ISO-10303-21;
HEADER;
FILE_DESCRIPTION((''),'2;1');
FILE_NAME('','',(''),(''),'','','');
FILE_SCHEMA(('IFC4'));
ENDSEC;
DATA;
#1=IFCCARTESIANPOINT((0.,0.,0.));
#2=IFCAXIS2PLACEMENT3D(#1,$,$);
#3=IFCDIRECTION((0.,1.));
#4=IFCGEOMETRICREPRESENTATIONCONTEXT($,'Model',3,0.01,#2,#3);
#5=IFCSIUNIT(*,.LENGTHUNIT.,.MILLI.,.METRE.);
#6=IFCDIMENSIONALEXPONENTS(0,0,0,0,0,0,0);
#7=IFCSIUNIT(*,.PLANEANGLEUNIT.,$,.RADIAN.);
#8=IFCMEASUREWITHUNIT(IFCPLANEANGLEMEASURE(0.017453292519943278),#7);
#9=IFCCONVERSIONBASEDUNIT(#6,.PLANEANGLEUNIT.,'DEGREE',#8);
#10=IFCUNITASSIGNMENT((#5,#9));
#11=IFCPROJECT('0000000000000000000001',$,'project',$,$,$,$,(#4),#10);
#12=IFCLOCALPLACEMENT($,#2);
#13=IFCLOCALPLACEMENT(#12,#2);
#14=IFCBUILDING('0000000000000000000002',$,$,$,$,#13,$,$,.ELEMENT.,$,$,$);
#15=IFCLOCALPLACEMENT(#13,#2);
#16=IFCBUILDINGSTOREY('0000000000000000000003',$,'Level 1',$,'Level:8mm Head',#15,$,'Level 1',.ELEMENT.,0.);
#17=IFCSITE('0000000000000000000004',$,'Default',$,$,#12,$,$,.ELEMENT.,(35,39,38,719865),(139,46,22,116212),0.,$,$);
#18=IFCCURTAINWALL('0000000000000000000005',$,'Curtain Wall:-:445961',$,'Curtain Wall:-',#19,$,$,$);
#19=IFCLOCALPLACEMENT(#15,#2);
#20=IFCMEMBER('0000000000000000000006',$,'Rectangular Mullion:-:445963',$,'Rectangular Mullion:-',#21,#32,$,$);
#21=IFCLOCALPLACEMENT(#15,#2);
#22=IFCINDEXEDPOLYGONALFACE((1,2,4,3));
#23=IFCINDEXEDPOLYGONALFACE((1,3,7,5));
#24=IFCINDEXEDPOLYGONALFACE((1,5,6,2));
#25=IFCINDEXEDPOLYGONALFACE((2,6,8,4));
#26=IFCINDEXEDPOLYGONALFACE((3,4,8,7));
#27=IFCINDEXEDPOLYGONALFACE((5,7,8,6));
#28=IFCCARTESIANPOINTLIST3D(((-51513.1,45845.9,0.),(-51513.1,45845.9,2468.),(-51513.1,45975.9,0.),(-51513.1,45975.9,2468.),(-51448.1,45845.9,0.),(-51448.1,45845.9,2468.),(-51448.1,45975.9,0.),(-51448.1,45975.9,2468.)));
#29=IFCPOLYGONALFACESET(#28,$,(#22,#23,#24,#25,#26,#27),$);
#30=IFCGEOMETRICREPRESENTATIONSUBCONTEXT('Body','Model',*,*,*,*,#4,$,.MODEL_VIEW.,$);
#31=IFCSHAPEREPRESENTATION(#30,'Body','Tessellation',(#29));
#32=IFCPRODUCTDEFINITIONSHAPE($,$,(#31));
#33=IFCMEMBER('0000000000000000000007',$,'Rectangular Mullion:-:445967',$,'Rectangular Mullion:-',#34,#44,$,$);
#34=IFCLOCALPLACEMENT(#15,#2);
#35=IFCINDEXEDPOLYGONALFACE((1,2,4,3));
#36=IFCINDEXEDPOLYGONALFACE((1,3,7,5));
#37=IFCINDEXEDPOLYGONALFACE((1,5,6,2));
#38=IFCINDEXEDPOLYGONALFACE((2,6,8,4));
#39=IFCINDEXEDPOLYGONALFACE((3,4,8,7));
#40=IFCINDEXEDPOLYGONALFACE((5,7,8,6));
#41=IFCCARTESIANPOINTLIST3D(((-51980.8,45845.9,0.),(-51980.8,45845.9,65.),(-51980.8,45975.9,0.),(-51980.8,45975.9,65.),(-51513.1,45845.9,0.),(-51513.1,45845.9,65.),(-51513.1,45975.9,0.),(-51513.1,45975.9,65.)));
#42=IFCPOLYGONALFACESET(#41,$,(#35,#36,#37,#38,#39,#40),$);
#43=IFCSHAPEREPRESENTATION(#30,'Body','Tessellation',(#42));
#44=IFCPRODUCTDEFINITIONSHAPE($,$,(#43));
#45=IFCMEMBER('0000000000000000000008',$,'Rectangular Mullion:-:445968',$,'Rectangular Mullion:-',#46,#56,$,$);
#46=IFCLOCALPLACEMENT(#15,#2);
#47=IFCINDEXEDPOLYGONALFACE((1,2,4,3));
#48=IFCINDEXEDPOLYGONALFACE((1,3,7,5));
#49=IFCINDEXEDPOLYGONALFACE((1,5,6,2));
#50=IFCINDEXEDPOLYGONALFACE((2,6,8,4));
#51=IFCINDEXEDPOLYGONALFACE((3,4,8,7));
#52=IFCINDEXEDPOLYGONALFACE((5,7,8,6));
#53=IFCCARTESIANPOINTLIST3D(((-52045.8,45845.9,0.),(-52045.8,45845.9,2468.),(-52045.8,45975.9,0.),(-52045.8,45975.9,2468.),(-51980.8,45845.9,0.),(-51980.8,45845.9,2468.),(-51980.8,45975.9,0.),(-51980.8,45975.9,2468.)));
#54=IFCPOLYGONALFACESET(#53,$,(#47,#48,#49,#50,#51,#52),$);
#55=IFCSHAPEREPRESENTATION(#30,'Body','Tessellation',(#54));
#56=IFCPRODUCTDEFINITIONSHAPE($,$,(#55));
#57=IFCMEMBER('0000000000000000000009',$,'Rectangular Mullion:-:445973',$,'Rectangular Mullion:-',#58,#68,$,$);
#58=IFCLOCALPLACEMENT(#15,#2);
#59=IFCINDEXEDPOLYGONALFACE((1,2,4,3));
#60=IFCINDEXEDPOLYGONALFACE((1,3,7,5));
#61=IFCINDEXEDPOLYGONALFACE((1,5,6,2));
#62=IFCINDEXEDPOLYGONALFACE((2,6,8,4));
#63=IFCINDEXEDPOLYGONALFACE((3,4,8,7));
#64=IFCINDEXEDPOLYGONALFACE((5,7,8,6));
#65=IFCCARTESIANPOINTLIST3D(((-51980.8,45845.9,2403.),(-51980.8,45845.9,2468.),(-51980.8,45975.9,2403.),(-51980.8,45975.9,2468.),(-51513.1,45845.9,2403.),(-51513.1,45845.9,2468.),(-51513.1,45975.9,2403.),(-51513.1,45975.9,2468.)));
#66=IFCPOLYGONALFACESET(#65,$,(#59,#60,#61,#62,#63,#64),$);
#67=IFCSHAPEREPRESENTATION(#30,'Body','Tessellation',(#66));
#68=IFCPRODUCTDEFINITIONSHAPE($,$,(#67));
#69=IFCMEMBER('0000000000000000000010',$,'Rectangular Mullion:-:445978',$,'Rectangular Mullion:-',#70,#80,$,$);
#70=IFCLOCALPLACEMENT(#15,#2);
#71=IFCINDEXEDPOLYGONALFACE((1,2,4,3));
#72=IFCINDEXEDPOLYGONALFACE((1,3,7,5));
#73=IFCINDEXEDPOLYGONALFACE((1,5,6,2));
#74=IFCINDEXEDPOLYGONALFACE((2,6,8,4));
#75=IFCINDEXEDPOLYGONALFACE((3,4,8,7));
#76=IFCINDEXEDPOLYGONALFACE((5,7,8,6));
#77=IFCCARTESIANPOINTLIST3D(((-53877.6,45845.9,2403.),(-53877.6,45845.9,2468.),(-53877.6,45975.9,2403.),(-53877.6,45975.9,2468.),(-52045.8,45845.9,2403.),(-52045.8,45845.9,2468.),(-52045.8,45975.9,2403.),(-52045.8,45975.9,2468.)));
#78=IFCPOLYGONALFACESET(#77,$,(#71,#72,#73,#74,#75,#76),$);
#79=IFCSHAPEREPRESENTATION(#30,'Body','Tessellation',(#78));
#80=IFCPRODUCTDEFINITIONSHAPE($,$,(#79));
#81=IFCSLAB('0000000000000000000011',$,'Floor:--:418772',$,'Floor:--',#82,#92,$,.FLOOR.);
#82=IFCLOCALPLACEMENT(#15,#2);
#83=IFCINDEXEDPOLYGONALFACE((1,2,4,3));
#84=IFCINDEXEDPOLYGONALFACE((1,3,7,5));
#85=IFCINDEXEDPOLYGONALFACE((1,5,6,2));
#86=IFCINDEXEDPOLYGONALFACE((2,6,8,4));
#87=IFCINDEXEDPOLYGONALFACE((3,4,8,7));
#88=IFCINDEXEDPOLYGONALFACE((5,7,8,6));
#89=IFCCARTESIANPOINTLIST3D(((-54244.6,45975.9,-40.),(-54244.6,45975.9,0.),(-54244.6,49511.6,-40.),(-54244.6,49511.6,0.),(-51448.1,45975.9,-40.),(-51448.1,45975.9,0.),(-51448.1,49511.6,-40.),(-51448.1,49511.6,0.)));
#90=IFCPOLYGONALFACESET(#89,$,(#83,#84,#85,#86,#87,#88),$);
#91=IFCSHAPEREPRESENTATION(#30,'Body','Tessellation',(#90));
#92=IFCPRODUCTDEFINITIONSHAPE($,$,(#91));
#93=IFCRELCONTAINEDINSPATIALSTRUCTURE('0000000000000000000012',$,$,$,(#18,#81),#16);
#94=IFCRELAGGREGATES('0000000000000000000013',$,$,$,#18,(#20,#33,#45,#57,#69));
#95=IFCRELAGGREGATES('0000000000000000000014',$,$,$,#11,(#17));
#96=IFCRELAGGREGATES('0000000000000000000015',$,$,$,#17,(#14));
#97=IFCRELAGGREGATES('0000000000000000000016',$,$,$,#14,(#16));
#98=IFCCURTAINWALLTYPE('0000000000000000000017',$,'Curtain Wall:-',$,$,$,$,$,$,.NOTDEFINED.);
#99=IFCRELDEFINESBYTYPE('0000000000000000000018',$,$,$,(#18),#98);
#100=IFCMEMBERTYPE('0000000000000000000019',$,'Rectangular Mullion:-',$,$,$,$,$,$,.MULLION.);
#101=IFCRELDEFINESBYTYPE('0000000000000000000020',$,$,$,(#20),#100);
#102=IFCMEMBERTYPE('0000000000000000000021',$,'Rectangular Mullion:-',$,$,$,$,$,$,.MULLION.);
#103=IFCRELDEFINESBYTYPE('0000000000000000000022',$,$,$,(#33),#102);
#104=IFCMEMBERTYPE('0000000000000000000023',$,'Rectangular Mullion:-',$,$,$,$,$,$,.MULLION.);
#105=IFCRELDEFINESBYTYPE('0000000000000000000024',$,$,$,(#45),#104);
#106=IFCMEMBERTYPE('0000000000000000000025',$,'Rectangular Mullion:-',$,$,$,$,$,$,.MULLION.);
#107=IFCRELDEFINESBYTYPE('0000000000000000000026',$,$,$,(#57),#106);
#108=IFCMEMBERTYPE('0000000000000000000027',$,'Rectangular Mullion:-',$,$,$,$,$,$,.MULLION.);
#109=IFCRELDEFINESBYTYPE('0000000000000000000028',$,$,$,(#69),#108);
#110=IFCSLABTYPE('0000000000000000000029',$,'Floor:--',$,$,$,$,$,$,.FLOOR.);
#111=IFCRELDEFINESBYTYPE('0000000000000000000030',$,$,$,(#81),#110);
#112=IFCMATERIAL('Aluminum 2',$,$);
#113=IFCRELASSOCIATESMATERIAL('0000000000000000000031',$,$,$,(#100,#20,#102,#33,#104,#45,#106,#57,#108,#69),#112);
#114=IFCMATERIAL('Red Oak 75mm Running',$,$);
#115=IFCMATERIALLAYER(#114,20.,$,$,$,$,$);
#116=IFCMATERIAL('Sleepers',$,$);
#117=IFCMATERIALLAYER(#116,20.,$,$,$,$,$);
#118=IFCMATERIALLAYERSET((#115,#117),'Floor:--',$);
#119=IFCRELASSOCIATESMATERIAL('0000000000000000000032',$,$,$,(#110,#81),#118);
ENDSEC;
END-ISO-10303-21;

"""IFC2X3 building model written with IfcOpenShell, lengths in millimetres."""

from ifc_helpers import new_model, entity, si_unit, converted_unit, direction, frame, frame_2d, origin, origin_2d_with_axis, place, context, subcontext, project, spatial, rectangle, extrude, source, transform, mapped, material, layer, layer_set, layer_usage, type_object, type_shapes, element, aggregate, save


model = new_model("IFC2X3")

# Units and contexts
model_context = context("Model", 3, precision=0.01, world=origin(), true_north=direction((0.0, 1.0)))
body_context = subcontext(model_context, "Body", "Model", "MODEL_VIEW")
ifc_project = project(units=[si_unit("LENGTHUNIT", "METRE", prefix="MILLI"), converted_unit("PLANEANGLEUNIT", "DEGREE", entity("IfcPlaneAngleMeasure", 0.017453292519943278), si_unit("PLANEANGLEUNIT", "RADIAN"), dimensions=[0, 0, 0, 0, 0, 0, 0])], contexts=[model_context])

# Site, building, storey
site_placement = place(None, origin())
site = spatial("IfcSite", under=ifc_project, at=site_placement, Name="Default", CompositionType="ELEMENT", RefLatitude=(35, 39, 38, 719865), RefLongitude=(139, 46, 22, 116212), RefElevation=0.0)
building_placement = place(site_placement, origin())
building = spatial("IfcBuilding", under=site, at=building_placement, CompositionType="ELEMENT")
storey_placement = place(building_placement, origin())
storey = spatial("IfcBuildingStorey", under=building, at=storey_placement, Name="Level 1", ObjectType="Level:8mm Head", LongName="Level 1", CompositionType="ELEMENT", Elevation=0.0)

# Curtain wall, members
curtain_wall_type = type_object("IfcCurtainWallType", Name="Curtain Wall:-", PredefinedType="NOTDEFINED")
curtain_wall_placement = place(storey_placement, origin())
curtain_wall = element("IfcCurtainWall", 1, at=curtain_wall_placement, inside=storey, type_object=curtain_wall_type, Name="Curtain Wall:-:445961", ObjectType="Curtain Wall:-")
ifc_material_1 = material(Name="Aluminum 2")
member_type_1 = type_object("IfcMemberType", Name="Rectangular Mullion:-", PredefinedType="MULLION", material=ifc_material_1)
shared_shape_1 = source(origin(), body_context, "Body", "SweptSolid", [
    extrude(rectangle(XDim=65.0, YDim=130.0, at=origin_2d_with_axis()), frame((-32.5, 0.0, -2468.0), z_axis=(0.0, 0.0, 1.0), x_axis=(-1.0, 0.0, 0.0)), (0.0, 0.0, 1.0), 2468.0),
])
type_shapes(member_type_1, [shared_shape_1])
member_1_placement = place(curtain_wall_placement, frame((-51448.1, 45910.9, 0.0), z_axis=(0.0, 0.0, -1.0), x_axis=(1.0, 0.0, 0.0)))
member_1 = element("IfcMember", 2, at=member_1_placement, type_object=member_type_1, material=ifc_material_1, Name="Rectangular Mullion:-:445963", ObjectType="Rectangular Mullion:-", context=body_context, shape_type="MappedRepresentation", body=[
    mapped(shared_shape_1, transform((0.0, 0.0, 0.0), scale=1.0)),
])
member_type_2 = type_object("IfcMemberType", Name="Rectangular Mullion:-", PredefinedType="MULLION", material=ifc_material_1)
shared_shape_2 = source(origin(), body_context, "Body", "SweptSolid", [
    extrude(rectangle(XDim=65.0, YDim=130.0, at=frame_2d((0.0, 0.0), x_axis=(1.0, 0.0))), frame((-32.5, 0.0, -467.6), z_axis=(0.0, 0.0, 1.0), x_axis=(-1.0, 0.0, 0.0)), (0.0, 0.0, 1.0), 467.6),
])
type_shapes(member_type_2, [shared_shape_2])
member_2_placement = place(curtain_wall_placement, frame((-51980.8, 45910.9, 0.0), z_axis=(-1.0, 0.0, 0.0), x_axis=(0.0, 0.0, -1.0)))
member_2 = element("IfcMember", 3, at=member_2_placement, type_object=member_type_2, material=ifc_material_1, Name="Rectangular Mullion:-:445967", ObjectType="Rectangular Mullion:-", context=body_context, shape_type="MappedRepresentation", body=[
    mapped(shared_shape_2, transform((0.0, 0.0, 0.0), scale=1.0)),
])
member_type_3 = type_object("IfcMemberType", Name="Rectangular Mullion:-", PredefinedType="MULLION", material=ifc_material_1)
shared_shape_3 = source(origin(), body_context, "Body", "SweptSolid", [
    extrude(rectangle(XDim=65.0, YDim=130.0, at=frame_2d((0.0, 0.0), x_axis=(1.0, 0.0))), frame((0.0, 0.0, -2468.0), z_axis=(0.0, 0.0, 1.0), x_axis=(-1.0, 0.0, 0.0)), (0.0, 0.0, 1.0), 2468.0),
])
type_shapes(member_type_3, [shared_shape_3])
member_3_placement = place(curtain_wall_placement, frame((-52013.3, 45910.9, 0.0), z_axis=(0.0, 0.0, -1.0), x_axis=(1.0, 0.0, 0.0)))
member_3 = element("IfcMember", 4, at=member_3_placement, type_object=member_type_3, material=ifc_material_1, Name="Rectangular Mullion:-:445968", ObjectType="Rectangular Mullion:-", context=body_context, shape_type="MappedRepresentation", body=[
    mapped(shared_shape_3, transform((0.0, 0.0, 0.0), scale=1.0)),
])
member_type_4 = type_object("IfcMemberType", Name="Rectangular Mullion:-", PredefinedType="MULLION", material=ifc_material_1)
shared_shape_4 = source(origin(), body_context, "Body", "SweptSolid", [
    extrude(rectangle(XDim=65.0, YDim=130.0, at=origin_2d_with_axis()), frame((0.0, 0.0, -467.6), z_axis=(0.0, 0.0, 1.0), x_axis=(-1.0, 0.0, 0.0)), (0.0, 0.0, 1.0), 467.6),
])
type_shapes(member_type_4, [shared_shape_4])
member_4_placement = place(curtain_wall_placement, frame((-51513.1, 45910.9, 2435.5), z_axis=(1.0, 0.0, 0.0), x_axis=(0.0, 0.0, 1.0)))
member_4 = element("IfcMember", 5, at=member_4_placement, type_object=member_type_4, material=ifc_material_1, Name="Rectangular Mullion:-:445973", ObjectType="Rectangular Mullion:-", context=body_context, shape_type="MappedRepresentation", body=[
    mapped(shared_shape_4, transform((0.0, 0.0, 0.0), scale=1.0)),
])
member_type_5 = type_object("IfcMemberType", Name="Rectangular Mullion:-", PredefinedType="MULLION", material=ifc_material_1)
shared_shape_5 = source(origin(), body_context, "Body", "SweptSolid", [
    extrude(rectangle(XDim=65.0, YDim=130.0, at=origin_2d_with_axis()), frame((0.0, 0.0, -1831.9), z_axis=(0.0, 0.0, 1.0), x_axis=(-1.0, 0.0, 0.0)), (0.0, 0.0, 1.0), 1831.9),
])
type_shapes(member_type_5, [shared_shape_5])
member_5_placement = place(curtain_wall_placement, frame((-52045.8, 45910.9, 2435.5), z_axis=(1.0, 0.0, 0.0), x_axis=(0.0, 0.0, 1.0)))
member_5 = element("IfcMember", 6, at=member_5_placement, type_object=member_type_5, material=ifc_material_1, Name="Rectangular Mullion:-:445978", ObjectType="Rectangular Mullion:-", context=body_context, shape_type="MappedRepresentation", body=[
    mapped(shared_shape_5, transform((0.0, 0.0, 0.0), scale=1.0)),
])

# Slab
ifc_material_2 = material(Name="Red Oak 75mm Running")
ifc_layer_1 = layer(ifc_material_2, 20.0)
ifc_material_3 = material(Name="Sleepers")
ifc_layer_2 = layer(ifc_material_3, 20.0)
ifc_layer_set_1 = layer_set([ifc_layer_1, ifc_layer_2], Name="Floor:--")
ifc_layer_usage_1 = layer_usage(ifc_layer_set_1, "AXIS3", "POSITIVE", 0.0)
slab_type_1 = type_object("IfcSlabType", Name="Floor:--", PredefinedType="FLOOR", material=ifc_layer_set_1)
slab_1_placement = place(storey_placement, origin())
element("IfcSlab", 7, at=slab_1_placement, inside=storey, type_object=slab_type_1, material=ifc_layer_usage_1, Name="Floor:--:418772", ObjectType="Floor:--", PredefinedType="FLOOR", context=body_context, shape_type="SweptSolid", body=[
    extrude(rectangle(XDim=3535.6, YDim=2796.4, at=frame_2d((0.0, 0.0), x_axis=(1.0, 0.0))), frame((-52846.3, 47743.7, 0.0), z_axis=(0.0, 0.0, -1.0), x_axis=(0.0, 1.0, 0.0)), (0.0, 0.0, 1.0), 40.0),
])

aggregate(curtain_wall, [member_1, member_2, member_3, member_4, member_5])

save(model, "model.ifc")
